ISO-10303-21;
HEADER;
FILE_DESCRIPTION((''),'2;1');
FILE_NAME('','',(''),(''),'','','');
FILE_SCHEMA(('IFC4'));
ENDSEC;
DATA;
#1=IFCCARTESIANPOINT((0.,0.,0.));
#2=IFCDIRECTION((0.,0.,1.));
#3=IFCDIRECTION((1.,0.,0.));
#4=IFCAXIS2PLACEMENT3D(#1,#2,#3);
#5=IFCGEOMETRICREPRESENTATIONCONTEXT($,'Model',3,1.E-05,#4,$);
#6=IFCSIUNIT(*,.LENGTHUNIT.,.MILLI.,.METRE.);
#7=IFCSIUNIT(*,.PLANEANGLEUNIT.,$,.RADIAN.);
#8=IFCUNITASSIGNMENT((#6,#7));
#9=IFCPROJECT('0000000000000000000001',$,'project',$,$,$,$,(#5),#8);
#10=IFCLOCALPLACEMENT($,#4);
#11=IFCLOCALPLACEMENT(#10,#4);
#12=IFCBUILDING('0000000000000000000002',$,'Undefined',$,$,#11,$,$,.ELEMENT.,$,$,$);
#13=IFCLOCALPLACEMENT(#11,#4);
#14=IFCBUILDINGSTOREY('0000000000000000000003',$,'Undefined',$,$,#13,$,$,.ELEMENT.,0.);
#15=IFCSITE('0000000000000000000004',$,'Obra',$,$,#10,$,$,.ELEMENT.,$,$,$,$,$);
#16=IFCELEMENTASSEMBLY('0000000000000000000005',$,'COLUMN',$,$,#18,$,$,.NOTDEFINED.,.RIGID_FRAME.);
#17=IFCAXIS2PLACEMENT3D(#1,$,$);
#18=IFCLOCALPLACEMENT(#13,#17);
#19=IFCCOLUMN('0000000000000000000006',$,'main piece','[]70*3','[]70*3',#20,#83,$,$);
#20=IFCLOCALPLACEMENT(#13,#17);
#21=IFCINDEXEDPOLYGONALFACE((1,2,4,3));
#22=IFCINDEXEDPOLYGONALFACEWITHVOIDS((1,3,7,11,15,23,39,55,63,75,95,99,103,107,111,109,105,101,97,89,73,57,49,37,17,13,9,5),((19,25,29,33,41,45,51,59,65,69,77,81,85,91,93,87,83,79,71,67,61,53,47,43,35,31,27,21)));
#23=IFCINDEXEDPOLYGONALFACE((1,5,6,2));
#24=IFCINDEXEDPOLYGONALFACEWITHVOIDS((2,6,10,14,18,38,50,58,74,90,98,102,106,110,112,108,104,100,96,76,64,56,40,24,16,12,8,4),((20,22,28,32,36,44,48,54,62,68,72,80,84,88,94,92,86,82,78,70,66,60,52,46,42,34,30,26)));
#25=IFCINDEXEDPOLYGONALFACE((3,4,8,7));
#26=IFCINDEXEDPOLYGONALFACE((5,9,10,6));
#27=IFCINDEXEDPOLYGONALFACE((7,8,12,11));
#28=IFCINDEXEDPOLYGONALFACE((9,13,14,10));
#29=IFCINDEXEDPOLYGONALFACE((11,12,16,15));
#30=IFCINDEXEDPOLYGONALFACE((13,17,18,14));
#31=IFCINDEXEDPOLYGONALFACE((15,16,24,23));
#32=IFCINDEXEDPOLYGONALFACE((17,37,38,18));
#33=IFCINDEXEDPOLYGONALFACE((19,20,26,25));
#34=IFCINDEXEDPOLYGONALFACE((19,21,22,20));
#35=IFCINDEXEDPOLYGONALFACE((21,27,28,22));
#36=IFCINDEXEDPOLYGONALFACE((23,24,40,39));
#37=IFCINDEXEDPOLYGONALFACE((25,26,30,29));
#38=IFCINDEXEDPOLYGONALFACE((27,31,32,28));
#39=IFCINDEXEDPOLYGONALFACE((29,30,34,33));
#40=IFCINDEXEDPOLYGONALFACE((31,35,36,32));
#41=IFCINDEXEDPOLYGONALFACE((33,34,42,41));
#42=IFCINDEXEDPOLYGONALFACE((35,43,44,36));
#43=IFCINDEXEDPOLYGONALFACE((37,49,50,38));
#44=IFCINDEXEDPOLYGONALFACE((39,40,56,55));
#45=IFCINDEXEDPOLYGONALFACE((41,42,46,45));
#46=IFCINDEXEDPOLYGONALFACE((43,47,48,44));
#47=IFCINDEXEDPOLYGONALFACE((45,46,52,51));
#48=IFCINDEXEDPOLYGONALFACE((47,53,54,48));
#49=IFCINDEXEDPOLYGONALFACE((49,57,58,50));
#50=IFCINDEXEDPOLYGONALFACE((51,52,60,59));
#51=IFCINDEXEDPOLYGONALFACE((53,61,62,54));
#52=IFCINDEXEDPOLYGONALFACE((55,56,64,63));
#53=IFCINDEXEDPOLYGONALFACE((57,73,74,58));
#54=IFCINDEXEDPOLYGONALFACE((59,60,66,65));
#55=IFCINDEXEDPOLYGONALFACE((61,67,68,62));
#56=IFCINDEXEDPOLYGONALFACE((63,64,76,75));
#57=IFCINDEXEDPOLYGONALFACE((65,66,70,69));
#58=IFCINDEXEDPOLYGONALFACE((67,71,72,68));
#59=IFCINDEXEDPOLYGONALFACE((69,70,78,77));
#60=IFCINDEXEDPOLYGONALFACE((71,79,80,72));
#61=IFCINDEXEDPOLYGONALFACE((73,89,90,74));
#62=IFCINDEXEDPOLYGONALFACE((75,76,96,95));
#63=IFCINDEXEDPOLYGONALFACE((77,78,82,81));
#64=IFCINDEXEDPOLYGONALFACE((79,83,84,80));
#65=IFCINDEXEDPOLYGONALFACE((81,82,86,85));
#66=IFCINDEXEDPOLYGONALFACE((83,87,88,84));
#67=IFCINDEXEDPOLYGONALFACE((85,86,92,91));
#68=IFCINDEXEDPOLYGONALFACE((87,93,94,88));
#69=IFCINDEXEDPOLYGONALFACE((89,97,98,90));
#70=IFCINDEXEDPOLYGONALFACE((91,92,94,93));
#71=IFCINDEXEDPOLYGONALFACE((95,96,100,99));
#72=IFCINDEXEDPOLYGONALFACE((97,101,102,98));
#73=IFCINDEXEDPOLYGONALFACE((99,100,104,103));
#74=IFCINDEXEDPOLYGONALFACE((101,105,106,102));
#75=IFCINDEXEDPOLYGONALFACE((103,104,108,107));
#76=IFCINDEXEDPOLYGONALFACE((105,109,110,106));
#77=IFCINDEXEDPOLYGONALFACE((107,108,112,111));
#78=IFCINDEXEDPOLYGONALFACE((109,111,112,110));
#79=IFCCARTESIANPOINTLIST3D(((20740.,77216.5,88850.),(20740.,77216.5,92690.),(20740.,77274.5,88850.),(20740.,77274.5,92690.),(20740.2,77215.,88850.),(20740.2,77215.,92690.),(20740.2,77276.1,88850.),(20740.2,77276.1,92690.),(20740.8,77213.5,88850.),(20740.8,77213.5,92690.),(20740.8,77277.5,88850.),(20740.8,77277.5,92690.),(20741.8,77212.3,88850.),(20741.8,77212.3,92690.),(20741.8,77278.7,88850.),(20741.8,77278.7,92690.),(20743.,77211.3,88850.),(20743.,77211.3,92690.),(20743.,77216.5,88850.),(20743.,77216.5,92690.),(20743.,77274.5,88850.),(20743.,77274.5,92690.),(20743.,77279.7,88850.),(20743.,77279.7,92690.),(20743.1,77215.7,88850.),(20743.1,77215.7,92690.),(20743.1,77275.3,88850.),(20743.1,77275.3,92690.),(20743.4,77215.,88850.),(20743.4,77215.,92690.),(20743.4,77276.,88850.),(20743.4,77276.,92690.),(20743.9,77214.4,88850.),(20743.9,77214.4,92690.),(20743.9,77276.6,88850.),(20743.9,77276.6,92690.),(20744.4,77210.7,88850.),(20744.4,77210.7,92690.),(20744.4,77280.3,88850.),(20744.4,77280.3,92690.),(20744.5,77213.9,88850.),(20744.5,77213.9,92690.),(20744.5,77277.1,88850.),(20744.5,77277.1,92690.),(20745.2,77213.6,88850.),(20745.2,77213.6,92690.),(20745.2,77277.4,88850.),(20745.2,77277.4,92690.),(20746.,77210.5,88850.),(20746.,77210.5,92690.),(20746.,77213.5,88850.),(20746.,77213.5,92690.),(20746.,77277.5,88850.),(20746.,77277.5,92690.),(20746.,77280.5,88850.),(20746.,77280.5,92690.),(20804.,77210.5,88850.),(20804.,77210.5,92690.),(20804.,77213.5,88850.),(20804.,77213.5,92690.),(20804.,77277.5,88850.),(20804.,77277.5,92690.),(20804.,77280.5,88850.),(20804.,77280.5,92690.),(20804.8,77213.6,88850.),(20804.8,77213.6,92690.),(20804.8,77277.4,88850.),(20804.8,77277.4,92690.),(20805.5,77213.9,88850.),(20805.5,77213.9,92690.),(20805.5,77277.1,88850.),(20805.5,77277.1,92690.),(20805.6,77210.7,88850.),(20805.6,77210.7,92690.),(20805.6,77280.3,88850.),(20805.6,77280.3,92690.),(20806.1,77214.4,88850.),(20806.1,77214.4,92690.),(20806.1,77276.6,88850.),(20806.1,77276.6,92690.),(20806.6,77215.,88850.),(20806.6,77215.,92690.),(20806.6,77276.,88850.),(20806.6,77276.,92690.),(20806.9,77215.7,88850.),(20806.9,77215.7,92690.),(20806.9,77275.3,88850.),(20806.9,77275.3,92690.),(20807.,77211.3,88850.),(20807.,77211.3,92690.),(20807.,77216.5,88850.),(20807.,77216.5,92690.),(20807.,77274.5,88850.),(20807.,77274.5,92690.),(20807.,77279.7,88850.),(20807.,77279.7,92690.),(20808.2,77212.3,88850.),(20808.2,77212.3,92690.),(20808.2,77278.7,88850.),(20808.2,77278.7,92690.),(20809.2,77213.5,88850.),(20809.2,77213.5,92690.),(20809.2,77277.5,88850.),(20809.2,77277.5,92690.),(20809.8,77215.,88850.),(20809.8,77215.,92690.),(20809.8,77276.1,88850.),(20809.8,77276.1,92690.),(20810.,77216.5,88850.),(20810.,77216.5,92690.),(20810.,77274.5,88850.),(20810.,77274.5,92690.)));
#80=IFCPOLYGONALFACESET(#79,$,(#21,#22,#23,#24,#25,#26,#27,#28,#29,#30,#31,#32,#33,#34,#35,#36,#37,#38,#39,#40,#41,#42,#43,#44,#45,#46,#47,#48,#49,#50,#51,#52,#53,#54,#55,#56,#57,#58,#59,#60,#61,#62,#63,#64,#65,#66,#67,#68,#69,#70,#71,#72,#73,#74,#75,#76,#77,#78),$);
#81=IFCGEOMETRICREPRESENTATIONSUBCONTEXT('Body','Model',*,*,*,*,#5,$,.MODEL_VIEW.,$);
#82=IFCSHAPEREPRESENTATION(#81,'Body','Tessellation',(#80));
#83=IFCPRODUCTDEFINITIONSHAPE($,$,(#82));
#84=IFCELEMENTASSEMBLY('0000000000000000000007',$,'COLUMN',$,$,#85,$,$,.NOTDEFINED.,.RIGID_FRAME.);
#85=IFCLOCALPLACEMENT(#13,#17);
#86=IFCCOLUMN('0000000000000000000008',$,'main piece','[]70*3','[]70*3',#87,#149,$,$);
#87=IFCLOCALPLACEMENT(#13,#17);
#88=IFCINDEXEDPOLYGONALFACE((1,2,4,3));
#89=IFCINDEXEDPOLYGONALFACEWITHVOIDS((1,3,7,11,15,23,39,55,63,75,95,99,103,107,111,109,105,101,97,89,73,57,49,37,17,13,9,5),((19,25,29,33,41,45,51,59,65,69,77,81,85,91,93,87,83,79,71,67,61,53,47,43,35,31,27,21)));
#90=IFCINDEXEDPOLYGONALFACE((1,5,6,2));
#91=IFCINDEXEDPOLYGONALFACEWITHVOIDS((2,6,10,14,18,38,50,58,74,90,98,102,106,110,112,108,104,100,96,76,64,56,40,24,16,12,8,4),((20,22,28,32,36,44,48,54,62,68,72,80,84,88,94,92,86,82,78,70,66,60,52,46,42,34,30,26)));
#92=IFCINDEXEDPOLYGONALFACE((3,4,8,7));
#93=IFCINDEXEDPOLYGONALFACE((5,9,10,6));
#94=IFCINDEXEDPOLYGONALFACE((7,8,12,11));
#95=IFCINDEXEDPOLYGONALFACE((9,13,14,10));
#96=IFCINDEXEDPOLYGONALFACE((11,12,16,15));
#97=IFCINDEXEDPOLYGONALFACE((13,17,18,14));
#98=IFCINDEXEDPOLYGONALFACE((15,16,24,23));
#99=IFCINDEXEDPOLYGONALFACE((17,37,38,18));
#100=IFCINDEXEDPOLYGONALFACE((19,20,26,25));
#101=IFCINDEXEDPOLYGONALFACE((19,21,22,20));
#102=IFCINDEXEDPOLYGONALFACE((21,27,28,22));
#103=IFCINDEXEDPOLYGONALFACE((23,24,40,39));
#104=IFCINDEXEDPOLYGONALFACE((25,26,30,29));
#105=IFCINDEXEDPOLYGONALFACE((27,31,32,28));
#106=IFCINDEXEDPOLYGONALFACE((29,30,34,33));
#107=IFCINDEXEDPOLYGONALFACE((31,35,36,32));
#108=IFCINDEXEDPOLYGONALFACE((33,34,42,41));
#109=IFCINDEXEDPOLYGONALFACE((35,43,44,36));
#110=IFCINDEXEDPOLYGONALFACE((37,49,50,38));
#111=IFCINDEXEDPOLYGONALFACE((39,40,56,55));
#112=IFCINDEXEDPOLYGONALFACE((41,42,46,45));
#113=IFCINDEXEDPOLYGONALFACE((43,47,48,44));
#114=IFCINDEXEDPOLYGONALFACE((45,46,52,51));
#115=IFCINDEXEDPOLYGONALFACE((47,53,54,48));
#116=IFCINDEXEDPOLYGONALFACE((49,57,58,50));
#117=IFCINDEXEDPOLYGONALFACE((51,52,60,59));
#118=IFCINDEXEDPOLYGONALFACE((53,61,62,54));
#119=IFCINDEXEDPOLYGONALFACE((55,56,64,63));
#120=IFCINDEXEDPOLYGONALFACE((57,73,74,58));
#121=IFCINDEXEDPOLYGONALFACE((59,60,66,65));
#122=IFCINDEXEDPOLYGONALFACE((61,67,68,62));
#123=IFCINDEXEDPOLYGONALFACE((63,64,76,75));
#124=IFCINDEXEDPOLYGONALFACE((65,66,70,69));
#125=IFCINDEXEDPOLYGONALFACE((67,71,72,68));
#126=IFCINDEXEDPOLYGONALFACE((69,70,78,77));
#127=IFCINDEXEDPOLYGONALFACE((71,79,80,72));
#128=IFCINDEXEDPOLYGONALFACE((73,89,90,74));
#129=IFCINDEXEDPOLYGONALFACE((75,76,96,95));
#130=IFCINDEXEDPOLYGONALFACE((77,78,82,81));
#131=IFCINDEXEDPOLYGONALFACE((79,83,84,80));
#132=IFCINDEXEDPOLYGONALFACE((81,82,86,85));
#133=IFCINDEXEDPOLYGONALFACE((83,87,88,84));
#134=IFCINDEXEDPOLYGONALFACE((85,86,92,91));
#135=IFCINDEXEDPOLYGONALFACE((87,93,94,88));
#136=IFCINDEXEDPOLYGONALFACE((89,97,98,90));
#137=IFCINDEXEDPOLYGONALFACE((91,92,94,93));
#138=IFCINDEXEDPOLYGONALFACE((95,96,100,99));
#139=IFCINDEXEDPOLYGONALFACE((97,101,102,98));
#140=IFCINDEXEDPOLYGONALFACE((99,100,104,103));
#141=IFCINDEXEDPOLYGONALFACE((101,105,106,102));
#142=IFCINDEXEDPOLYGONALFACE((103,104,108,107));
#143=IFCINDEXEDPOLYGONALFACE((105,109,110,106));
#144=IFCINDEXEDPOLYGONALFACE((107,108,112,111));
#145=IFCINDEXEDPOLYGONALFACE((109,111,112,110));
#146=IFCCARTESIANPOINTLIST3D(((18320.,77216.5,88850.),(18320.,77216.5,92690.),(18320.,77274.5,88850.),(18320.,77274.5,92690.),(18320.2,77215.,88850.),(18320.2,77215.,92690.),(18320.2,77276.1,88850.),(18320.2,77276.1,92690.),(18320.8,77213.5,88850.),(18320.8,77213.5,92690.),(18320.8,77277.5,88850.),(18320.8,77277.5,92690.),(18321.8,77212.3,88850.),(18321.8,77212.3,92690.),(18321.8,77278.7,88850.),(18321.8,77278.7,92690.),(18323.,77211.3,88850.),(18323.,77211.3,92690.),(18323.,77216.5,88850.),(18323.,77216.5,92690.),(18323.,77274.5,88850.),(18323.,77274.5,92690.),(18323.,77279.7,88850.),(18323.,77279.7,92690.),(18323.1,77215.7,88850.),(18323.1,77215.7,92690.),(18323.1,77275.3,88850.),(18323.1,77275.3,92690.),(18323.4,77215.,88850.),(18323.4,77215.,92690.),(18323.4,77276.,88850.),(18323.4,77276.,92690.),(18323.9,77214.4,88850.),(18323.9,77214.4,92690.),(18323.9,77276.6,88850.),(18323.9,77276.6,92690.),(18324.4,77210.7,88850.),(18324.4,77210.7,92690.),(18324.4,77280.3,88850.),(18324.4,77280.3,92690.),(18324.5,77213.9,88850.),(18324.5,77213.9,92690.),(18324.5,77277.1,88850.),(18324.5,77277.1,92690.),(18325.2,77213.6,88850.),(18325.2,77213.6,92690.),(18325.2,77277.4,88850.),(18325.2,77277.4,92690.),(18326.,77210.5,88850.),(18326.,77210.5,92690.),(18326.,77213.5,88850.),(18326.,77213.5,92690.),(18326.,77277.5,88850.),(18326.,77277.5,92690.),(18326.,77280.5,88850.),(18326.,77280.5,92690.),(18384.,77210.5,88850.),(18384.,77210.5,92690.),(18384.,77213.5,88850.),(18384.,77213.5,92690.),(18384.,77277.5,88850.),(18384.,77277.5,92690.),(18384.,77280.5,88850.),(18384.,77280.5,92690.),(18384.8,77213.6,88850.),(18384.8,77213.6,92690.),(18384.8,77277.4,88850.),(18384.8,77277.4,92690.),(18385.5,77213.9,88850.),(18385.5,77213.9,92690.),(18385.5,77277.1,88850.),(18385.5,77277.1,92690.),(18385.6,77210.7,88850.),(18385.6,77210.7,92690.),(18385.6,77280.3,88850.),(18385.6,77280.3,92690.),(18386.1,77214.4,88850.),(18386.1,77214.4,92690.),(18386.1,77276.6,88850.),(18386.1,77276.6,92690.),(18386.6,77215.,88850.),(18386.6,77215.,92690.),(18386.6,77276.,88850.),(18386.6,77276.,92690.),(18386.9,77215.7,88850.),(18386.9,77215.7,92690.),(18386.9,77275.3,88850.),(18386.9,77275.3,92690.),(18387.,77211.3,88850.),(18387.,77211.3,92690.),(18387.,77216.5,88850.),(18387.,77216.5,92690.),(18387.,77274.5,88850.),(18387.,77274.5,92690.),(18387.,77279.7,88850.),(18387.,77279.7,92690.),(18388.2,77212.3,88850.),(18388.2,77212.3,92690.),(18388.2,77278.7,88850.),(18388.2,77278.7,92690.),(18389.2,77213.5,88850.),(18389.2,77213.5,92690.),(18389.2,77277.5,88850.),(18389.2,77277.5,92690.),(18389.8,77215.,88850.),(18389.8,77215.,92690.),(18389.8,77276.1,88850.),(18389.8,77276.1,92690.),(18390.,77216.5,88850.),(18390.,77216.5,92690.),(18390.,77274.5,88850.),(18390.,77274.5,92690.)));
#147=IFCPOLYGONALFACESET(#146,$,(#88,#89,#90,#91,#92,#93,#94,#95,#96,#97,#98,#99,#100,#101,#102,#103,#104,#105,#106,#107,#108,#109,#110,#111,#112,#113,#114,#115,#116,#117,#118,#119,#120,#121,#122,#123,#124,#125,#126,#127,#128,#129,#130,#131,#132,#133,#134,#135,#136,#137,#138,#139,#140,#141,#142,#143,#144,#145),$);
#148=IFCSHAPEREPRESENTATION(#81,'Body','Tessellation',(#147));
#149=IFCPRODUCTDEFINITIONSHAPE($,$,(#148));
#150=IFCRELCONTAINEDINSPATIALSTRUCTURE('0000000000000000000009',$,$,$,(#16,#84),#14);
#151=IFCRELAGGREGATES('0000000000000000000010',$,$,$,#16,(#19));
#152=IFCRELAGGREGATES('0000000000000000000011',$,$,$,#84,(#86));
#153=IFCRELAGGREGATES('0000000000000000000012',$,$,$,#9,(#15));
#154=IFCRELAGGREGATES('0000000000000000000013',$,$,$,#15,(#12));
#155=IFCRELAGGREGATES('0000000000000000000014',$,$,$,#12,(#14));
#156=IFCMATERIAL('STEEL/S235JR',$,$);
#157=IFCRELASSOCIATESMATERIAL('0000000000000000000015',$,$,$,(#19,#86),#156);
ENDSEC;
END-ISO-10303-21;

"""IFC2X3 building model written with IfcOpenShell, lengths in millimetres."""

from ifc_helpers import new_model, si_unit, frame, origin_with_axes, origin_2d_with_axis, place, context, subcontext, project, spatial, hollow_rectangle, extrude, material, element, aggregate, save


model = new_model("IFC2X3")

# Units and contexts
model_context = context("Model", 3, precision=1e-05, world=origin_with_axes())
body_context = subcontext(model_context, "Body", "Model", "MODEL_VIEW")
ifc_project = project(units=[si_unit("LENGTHUNIT", "METRE", prefix="MILLI"), si_unit("PLANEANGLEUNIT", "RADIAN")], contexts=[model_context])

# Site, building, storey
site_placement = place(None, origin_with_axes())
site = spatial("IfcSite", under=ifc_project, at=site_placement, Name="Obra", CompositionType="ELEMENT")
building_placement = place(site_placement, origin_with_axes())
building = spatial("IfcBuilding", under=site, at=building_placement, Name="Undefined", CompositionType="ELEMENT")
storey_placement = place(building_placement, origin_with_axes())
storey = spatial("IfcBuildingStorey", under=building, at=storey_placement, Name="Undefined", CompositionType="ELEMENT", Elevation=0.0)

# Element assemblies, columns
ifc_material = material(Name="STEEL/S235JR")
assembly_1_placement = place(storey_placement, origin_with_axes())
assembly_1 = element("IfcElementAssembly", 1, at=assembly_1_placement, inside=storey, Name="COLUMN", AssemblyPlace="NOTDEFINED", PredefinedType="RIGID_FRAME")
column_1_placement = place(assembly_1_placement, frame((20775.0, 77245.5, 88850.0), z_axis=(0.0, 0.0, 1.0), x_axis=(0.0, 1.0, 0.0)))
column_1 = element("IfcColumn", 2, at=column_1_placement, material=ifc_material, Name="main piece", Description="[]70*3", ObjectType="[]70*3", context=body_context, shape_type="SweptSolid", body=[
    extrude(hollow_rectangle(XDim=70.0, YDim=70.0, WallThickness=3.0, InnerFilletRadius=3.0, OuterFilletRadius=6.0, at=origin_2d_with_axis()), frame((0.0, 0.0, 3840.0), z_axis=(0.0, 0.0, -1.0), x_axis=(0.0, 1.0, 0.0)), (0.0, 0.0, 1.0), 3840.0),
])
aggregate(assembly_1, [column_1])
assembly_2_placement = place(storey_placement, origin_with_axes())
assembly_2 = element("IfcElementAssembly", 3, at=assembly_2_placement, inside=storey, Name="COLUMN", AssemblyPlace="NOTDEFINED", PredefinedType="RIGID_FRAME")
column_2_placement = place(assembly_2_placement, frame((18355.0, 77245.5, 88850.0), z_axis=(0.0, 0.0, 1.0), x_axis=(0.0, 1.0, 0.0)))
column_2 = element("IfcColumn", 4, at=column_2_placement, material=ifc_material, Name="main piece", Description="[]70*3", ObjectType="[]70*3", context=body_context, shape_type="SweptSolid", body=[
    extrude(hollow_rectangle(XDim=70.0, YDim=70.0, WallThickness=3.0, InnerFilletRadius=3.0, OuterFilletRadius=6.0, at=origin_2d_with_axis()), frame((0.0, 0.0, 3840.0), z_axis=(0.0, 0.0, -1.0), x_axis=(0.0, 1.0, 0.0)), (0.0, 0.0, 1.0), 3840.0),
])
aggregate(assembly_2, [column_2])

save(model, "model.ifc")
